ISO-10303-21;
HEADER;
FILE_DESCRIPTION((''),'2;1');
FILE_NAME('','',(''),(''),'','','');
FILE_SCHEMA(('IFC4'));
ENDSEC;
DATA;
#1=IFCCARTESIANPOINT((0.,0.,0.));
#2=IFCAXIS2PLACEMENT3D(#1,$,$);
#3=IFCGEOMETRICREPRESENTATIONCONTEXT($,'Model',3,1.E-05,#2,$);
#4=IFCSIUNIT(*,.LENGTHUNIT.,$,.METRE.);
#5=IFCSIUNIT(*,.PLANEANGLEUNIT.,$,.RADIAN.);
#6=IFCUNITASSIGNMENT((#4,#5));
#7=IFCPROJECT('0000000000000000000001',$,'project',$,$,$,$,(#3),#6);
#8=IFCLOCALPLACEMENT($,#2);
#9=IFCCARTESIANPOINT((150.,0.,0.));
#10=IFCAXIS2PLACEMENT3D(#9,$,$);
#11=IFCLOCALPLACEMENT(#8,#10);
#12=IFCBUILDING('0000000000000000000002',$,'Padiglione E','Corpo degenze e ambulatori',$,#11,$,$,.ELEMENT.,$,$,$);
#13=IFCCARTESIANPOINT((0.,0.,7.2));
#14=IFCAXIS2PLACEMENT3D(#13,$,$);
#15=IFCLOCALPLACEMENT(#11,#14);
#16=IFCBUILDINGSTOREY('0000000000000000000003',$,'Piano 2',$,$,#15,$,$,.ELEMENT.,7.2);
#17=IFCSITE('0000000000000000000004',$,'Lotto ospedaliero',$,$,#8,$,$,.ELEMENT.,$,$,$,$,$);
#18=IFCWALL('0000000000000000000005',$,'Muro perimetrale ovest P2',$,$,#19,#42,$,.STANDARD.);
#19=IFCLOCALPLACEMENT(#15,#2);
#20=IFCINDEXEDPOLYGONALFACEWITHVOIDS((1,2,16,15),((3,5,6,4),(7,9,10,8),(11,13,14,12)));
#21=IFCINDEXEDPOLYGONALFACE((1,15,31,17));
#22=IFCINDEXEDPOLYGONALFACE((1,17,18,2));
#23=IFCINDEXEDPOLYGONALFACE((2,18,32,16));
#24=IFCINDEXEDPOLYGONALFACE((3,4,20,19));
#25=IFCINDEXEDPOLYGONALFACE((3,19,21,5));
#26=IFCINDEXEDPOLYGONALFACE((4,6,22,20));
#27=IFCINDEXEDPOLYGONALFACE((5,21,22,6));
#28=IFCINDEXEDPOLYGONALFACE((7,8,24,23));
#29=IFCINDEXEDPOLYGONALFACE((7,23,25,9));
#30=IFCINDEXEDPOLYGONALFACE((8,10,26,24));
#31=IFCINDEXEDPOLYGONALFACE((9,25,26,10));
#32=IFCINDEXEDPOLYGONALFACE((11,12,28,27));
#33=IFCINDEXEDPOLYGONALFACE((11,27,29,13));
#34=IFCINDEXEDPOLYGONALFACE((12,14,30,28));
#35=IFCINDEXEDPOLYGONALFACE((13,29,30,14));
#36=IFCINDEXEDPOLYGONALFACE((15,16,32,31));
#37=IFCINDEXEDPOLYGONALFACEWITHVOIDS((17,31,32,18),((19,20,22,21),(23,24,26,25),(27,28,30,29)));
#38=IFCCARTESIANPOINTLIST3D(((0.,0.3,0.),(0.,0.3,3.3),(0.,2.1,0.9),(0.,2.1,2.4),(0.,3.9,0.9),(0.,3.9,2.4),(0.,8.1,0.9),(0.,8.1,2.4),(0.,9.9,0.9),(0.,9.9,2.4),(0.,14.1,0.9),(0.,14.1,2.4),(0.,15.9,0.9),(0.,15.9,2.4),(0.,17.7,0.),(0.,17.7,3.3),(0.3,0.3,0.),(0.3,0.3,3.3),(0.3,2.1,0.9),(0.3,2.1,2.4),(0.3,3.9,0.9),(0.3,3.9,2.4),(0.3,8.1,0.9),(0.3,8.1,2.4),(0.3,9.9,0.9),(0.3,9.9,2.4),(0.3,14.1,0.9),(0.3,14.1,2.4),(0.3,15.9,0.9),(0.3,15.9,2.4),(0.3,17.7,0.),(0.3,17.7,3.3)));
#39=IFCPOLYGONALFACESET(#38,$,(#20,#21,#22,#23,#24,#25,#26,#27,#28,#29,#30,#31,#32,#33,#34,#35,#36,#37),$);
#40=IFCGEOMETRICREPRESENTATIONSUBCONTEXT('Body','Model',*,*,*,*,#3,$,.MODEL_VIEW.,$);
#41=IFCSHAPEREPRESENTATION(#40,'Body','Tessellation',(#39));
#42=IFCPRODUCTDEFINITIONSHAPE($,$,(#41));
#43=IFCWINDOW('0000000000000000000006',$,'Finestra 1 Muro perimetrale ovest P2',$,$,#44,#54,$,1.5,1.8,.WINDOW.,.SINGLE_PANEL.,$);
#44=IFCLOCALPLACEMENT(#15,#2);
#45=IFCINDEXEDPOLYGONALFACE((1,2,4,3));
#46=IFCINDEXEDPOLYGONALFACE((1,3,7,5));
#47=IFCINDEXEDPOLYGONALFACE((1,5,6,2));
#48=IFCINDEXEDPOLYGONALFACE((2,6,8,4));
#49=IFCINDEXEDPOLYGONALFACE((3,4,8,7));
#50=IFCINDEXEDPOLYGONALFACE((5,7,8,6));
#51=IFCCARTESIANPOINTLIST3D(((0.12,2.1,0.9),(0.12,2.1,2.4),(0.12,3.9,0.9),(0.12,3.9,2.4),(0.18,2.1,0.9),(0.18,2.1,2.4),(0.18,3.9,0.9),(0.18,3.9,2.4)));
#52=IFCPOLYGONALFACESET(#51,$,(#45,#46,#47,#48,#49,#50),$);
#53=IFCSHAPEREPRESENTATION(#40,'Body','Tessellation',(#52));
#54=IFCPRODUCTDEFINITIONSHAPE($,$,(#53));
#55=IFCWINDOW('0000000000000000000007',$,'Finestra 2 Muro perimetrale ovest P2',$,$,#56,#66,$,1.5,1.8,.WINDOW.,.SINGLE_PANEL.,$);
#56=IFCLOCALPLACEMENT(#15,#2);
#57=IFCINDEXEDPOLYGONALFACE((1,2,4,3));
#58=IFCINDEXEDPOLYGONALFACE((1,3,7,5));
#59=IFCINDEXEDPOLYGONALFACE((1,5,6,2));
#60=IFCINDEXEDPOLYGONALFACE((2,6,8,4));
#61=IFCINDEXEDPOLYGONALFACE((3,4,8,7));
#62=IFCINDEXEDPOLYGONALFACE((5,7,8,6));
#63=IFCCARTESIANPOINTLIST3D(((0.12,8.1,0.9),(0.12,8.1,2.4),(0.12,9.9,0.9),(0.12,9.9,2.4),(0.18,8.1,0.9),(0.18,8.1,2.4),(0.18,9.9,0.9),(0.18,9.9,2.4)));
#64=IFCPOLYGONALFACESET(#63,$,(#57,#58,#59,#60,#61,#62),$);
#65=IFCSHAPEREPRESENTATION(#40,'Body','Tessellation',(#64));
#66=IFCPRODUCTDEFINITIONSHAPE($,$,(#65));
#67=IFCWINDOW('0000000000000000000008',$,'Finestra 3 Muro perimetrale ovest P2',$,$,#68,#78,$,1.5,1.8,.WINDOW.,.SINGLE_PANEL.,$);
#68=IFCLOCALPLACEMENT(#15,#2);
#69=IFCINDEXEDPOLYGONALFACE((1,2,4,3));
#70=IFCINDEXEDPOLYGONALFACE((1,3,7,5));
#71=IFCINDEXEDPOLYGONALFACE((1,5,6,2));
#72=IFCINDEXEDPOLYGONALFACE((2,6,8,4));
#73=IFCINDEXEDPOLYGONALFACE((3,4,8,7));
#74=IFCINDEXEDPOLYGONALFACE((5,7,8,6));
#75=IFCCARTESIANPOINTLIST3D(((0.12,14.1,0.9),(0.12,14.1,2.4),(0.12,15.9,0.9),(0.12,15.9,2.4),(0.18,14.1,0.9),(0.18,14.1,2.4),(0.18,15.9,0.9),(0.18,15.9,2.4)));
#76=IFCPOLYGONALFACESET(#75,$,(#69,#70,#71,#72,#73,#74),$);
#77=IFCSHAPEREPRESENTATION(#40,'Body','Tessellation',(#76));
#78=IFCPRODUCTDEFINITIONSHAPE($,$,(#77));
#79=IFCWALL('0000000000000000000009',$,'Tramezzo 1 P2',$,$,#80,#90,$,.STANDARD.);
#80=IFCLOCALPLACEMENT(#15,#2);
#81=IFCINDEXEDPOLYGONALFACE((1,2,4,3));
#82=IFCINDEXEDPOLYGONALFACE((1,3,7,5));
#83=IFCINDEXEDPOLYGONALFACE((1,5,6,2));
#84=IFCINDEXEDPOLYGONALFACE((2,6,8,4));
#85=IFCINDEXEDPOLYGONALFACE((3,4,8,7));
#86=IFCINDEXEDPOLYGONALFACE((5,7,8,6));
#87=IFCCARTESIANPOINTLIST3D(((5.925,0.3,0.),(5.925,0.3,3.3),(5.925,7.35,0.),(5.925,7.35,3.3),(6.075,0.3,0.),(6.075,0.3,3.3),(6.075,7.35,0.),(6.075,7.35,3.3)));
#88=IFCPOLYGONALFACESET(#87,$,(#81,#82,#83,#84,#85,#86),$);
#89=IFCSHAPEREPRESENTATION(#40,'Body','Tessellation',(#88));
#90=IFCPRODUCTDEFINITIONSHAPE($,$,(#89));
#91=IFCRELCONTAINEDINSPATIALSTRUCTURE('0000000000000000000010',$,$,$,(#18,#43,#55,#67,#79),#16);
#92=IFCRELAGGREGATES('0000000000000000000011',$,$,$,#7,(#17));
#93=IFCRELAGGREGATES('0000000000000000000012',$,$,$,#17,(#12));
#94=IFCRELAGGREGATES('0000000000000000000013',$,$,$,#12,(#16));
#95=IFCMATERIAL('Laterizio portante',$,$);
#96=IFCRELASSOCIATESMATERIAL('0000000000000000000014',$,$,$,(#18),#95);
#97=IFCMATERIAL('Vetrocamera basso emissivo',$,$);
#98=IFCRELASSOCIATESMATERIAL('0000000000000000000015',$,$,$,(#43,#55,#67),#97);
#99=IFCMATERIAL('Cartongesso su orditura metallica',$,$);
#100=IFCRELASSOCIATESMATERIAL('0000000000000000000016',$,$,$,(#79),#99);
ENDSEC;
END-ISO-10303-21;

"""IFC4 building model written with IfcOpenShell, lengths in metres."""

from ifc_helpers import new_model, si_unit, frame, frame_2d, origin, place, context, subcontext, project, spatial, rectangle, extrude, material, element, fill, save


model = new_model("IFC4")

# Units and contexts
model_context = context("Model", 3, precision=1e-05, world=origin())
body_context = subcontext(model_context, "Body", "Model", "MODEL_VIEW")
ifc_project = project(units=[si_unit("LENGTHUNIT", "METRE"), si_unit("PLANEANGLEUNIT", "RADIAN")], contexts=[model_context])

# Site, building, storey
site_placement = place(None, origin())
site = spatial("IfcSite", under=ifc_project, at=site_placement, Name="Lotto ospedaliero", CompositionType="ELEMENT")
building_placement = place(site_placement, frame((150.0, 0.0, 0.0)))
building = spatial("IfcBuilding", under=site, at=building_placement, Name="Padiglione E", Description="Corpo degenze e ambulatori", CompositionType="ELEMENT")
storey_placement = place(building_placement, frame((0.0, 0.0, 7.2)))
storey = spatial("IfcBuildingStorey", under=building, at=storey_placement, Name="Piano 2", CompositionType="ELEMENT", Elevation=7.2)

# Wall, openings, windows
ifc_material_1 = material(Name="Laterizio portante")
ifc_material_2 = material(Name="Vetrocamera basso emissivo")
wall_1_placement = place(storey_placement, frame((0.0, 0.3, 0.0)))
wall_1 = element("IfcWall", 1, at=wall_1_placement, inside=storey, material=ifc_material_1, Name="Muro perimetrale ovest P2", PredefinedType="STANDARD", context=body_context, shape_type="SweptSolid", body=[
    extrude(rectangle(XDim=0.3, YDim=17.4, at=frame_2d((0.15, 8.7))), origin(), (0.0, 0.0, 1.0), 3.3),
])
opening_1_placement = place(wall_1_placement, frame((-0.1, 1.8, 0.9)))
opening_1 = element("IfcOpeningElement", 2, at=opening_1_placement, cuts=wall_1, PredefinedType="OPENING", context=body_context, shape_type="SweptSolid", body=[
    extrude(rectangle(XDim=0.5, YDim=1.8, at=frame_2d((0.25, 0.9))), origin(), (0.0, 0.0, 1.0), 1.5),
])
opening_2_placement = place(wall_1_placement, frame((-0.1, 7.8, 0.9)))
opening_2 = element("IfcOpeningElement", 3, at=opening_2_placement, cuts=wall_1, PredefinedType="OPENING", context=body_context, shape_type="SweptSolid", body=[
    extrude(rectangle(XDim=0.5, YDim=1.8, at=frame_2d((0.25, 0.9))), origin(), (0.0, 0.0, 1.0), 1.5),
])
opening_3_placement = place(wall_1_placement, frame((-0.1, 13.8, 0.9)))
opening_3 = element("IfcOpeningElement", 4, at=opening_3_placement, cuts=wall_1, PredefinedType="OPENING", context=body_context, shape_type="SweptSolid", body=[
    extrude(rectangle(XDim=0.5, YDim=1.8, at=frame_2d((0.25, 0.9))), origin(), (0.0, 0.0, 1.0), 1.5),
])
window_1_placement = place(wall_1_placement, frame((0.12, 1.8, 0.9)))
window_1 = element("IfcWindow", 5, at=window_1_placement, inside=storey, material=ifc_material_2, Name="Finestra 1 Muro perimetrale ovest P2", OverallHeight=1.5, OverallWidth=1.8, PartitioningType="SINGLE_PANEL", PredefinedType="WINDOW", context=body_context, shape_type="SweptSolid", body=[
    extrude(rectangle(XDim=0.06, YDim=1.8, at=frame_2d((0.03, 0.9))), origin(), (0.0, 0.0, 1.0), 1.5),
])
fill(opening_1, window_1)
window_2_placement = place(wall_1_placement, frame((0.12, 7.8, 0.9)))
window_2 = element("IfcWindow", 6, at=window_2_placement, inside=storey, material=ifc_material_2, Name="Finestra 2 Muro perimetrale ovest P2", OverallHeight=1.5, OverallWidth=1.8, PartitioningType="SINGLE_PANEL", PredefinedType="WINDOW", context=body_context, shape_type="SweptSolid", body=[
    extrude(rectangle(XDim=0.06, YDim=1.8, at=frame_2d((0.03, 0.9))), origin(), (0.0, 0.0, 1.0), 1.5),
])
fill(opening_2, window_2)
window_3_placement = place(wall_1_placement, frame((0.12, 13.8, 0.9)))
window_3 = element("IfcWindow", 7, at=window_3_placement, inside=storey, material=ifc_material_2, Name="Finestra 3 Muro perimetrale ovest P2", OverallHeight=1.5, OverallWidth=1.8, PartitioningType="SINGLE_PANEL", PredefinedType="WINDOW", context=body_context, shape_type="SweptSolid", body=[
    extrude(rectangle(XDim=0.06, YDim=1.8, at=frame_2d((0.03, 0.9))), origin(), (0.0, 0.0, 1.0), 1.5),
])
fill(opening_3, window_3)

# Wall
ifc_material_3 = material(Name="Cartongesso su orditura metallica")
wall_2_placement = place(storey_placement, frame((5.925, 0.3, 0.0)))
element("IfcWall", 8, at=wall_2_placement, inside=storey, material=ifc_material_3, Name="Tramezzo 1 P2", PredefinedType="STANDARD", context=body_context, shape_type="SweptSolid", body=[
    extrude(rectangle(XDim=0.15, YDim=7.05, at=frame_2d((0.075, 3.525))), origin(), (0.0, 0.0, 1.0), 3.3),
])

save(model, "model.ifc")
